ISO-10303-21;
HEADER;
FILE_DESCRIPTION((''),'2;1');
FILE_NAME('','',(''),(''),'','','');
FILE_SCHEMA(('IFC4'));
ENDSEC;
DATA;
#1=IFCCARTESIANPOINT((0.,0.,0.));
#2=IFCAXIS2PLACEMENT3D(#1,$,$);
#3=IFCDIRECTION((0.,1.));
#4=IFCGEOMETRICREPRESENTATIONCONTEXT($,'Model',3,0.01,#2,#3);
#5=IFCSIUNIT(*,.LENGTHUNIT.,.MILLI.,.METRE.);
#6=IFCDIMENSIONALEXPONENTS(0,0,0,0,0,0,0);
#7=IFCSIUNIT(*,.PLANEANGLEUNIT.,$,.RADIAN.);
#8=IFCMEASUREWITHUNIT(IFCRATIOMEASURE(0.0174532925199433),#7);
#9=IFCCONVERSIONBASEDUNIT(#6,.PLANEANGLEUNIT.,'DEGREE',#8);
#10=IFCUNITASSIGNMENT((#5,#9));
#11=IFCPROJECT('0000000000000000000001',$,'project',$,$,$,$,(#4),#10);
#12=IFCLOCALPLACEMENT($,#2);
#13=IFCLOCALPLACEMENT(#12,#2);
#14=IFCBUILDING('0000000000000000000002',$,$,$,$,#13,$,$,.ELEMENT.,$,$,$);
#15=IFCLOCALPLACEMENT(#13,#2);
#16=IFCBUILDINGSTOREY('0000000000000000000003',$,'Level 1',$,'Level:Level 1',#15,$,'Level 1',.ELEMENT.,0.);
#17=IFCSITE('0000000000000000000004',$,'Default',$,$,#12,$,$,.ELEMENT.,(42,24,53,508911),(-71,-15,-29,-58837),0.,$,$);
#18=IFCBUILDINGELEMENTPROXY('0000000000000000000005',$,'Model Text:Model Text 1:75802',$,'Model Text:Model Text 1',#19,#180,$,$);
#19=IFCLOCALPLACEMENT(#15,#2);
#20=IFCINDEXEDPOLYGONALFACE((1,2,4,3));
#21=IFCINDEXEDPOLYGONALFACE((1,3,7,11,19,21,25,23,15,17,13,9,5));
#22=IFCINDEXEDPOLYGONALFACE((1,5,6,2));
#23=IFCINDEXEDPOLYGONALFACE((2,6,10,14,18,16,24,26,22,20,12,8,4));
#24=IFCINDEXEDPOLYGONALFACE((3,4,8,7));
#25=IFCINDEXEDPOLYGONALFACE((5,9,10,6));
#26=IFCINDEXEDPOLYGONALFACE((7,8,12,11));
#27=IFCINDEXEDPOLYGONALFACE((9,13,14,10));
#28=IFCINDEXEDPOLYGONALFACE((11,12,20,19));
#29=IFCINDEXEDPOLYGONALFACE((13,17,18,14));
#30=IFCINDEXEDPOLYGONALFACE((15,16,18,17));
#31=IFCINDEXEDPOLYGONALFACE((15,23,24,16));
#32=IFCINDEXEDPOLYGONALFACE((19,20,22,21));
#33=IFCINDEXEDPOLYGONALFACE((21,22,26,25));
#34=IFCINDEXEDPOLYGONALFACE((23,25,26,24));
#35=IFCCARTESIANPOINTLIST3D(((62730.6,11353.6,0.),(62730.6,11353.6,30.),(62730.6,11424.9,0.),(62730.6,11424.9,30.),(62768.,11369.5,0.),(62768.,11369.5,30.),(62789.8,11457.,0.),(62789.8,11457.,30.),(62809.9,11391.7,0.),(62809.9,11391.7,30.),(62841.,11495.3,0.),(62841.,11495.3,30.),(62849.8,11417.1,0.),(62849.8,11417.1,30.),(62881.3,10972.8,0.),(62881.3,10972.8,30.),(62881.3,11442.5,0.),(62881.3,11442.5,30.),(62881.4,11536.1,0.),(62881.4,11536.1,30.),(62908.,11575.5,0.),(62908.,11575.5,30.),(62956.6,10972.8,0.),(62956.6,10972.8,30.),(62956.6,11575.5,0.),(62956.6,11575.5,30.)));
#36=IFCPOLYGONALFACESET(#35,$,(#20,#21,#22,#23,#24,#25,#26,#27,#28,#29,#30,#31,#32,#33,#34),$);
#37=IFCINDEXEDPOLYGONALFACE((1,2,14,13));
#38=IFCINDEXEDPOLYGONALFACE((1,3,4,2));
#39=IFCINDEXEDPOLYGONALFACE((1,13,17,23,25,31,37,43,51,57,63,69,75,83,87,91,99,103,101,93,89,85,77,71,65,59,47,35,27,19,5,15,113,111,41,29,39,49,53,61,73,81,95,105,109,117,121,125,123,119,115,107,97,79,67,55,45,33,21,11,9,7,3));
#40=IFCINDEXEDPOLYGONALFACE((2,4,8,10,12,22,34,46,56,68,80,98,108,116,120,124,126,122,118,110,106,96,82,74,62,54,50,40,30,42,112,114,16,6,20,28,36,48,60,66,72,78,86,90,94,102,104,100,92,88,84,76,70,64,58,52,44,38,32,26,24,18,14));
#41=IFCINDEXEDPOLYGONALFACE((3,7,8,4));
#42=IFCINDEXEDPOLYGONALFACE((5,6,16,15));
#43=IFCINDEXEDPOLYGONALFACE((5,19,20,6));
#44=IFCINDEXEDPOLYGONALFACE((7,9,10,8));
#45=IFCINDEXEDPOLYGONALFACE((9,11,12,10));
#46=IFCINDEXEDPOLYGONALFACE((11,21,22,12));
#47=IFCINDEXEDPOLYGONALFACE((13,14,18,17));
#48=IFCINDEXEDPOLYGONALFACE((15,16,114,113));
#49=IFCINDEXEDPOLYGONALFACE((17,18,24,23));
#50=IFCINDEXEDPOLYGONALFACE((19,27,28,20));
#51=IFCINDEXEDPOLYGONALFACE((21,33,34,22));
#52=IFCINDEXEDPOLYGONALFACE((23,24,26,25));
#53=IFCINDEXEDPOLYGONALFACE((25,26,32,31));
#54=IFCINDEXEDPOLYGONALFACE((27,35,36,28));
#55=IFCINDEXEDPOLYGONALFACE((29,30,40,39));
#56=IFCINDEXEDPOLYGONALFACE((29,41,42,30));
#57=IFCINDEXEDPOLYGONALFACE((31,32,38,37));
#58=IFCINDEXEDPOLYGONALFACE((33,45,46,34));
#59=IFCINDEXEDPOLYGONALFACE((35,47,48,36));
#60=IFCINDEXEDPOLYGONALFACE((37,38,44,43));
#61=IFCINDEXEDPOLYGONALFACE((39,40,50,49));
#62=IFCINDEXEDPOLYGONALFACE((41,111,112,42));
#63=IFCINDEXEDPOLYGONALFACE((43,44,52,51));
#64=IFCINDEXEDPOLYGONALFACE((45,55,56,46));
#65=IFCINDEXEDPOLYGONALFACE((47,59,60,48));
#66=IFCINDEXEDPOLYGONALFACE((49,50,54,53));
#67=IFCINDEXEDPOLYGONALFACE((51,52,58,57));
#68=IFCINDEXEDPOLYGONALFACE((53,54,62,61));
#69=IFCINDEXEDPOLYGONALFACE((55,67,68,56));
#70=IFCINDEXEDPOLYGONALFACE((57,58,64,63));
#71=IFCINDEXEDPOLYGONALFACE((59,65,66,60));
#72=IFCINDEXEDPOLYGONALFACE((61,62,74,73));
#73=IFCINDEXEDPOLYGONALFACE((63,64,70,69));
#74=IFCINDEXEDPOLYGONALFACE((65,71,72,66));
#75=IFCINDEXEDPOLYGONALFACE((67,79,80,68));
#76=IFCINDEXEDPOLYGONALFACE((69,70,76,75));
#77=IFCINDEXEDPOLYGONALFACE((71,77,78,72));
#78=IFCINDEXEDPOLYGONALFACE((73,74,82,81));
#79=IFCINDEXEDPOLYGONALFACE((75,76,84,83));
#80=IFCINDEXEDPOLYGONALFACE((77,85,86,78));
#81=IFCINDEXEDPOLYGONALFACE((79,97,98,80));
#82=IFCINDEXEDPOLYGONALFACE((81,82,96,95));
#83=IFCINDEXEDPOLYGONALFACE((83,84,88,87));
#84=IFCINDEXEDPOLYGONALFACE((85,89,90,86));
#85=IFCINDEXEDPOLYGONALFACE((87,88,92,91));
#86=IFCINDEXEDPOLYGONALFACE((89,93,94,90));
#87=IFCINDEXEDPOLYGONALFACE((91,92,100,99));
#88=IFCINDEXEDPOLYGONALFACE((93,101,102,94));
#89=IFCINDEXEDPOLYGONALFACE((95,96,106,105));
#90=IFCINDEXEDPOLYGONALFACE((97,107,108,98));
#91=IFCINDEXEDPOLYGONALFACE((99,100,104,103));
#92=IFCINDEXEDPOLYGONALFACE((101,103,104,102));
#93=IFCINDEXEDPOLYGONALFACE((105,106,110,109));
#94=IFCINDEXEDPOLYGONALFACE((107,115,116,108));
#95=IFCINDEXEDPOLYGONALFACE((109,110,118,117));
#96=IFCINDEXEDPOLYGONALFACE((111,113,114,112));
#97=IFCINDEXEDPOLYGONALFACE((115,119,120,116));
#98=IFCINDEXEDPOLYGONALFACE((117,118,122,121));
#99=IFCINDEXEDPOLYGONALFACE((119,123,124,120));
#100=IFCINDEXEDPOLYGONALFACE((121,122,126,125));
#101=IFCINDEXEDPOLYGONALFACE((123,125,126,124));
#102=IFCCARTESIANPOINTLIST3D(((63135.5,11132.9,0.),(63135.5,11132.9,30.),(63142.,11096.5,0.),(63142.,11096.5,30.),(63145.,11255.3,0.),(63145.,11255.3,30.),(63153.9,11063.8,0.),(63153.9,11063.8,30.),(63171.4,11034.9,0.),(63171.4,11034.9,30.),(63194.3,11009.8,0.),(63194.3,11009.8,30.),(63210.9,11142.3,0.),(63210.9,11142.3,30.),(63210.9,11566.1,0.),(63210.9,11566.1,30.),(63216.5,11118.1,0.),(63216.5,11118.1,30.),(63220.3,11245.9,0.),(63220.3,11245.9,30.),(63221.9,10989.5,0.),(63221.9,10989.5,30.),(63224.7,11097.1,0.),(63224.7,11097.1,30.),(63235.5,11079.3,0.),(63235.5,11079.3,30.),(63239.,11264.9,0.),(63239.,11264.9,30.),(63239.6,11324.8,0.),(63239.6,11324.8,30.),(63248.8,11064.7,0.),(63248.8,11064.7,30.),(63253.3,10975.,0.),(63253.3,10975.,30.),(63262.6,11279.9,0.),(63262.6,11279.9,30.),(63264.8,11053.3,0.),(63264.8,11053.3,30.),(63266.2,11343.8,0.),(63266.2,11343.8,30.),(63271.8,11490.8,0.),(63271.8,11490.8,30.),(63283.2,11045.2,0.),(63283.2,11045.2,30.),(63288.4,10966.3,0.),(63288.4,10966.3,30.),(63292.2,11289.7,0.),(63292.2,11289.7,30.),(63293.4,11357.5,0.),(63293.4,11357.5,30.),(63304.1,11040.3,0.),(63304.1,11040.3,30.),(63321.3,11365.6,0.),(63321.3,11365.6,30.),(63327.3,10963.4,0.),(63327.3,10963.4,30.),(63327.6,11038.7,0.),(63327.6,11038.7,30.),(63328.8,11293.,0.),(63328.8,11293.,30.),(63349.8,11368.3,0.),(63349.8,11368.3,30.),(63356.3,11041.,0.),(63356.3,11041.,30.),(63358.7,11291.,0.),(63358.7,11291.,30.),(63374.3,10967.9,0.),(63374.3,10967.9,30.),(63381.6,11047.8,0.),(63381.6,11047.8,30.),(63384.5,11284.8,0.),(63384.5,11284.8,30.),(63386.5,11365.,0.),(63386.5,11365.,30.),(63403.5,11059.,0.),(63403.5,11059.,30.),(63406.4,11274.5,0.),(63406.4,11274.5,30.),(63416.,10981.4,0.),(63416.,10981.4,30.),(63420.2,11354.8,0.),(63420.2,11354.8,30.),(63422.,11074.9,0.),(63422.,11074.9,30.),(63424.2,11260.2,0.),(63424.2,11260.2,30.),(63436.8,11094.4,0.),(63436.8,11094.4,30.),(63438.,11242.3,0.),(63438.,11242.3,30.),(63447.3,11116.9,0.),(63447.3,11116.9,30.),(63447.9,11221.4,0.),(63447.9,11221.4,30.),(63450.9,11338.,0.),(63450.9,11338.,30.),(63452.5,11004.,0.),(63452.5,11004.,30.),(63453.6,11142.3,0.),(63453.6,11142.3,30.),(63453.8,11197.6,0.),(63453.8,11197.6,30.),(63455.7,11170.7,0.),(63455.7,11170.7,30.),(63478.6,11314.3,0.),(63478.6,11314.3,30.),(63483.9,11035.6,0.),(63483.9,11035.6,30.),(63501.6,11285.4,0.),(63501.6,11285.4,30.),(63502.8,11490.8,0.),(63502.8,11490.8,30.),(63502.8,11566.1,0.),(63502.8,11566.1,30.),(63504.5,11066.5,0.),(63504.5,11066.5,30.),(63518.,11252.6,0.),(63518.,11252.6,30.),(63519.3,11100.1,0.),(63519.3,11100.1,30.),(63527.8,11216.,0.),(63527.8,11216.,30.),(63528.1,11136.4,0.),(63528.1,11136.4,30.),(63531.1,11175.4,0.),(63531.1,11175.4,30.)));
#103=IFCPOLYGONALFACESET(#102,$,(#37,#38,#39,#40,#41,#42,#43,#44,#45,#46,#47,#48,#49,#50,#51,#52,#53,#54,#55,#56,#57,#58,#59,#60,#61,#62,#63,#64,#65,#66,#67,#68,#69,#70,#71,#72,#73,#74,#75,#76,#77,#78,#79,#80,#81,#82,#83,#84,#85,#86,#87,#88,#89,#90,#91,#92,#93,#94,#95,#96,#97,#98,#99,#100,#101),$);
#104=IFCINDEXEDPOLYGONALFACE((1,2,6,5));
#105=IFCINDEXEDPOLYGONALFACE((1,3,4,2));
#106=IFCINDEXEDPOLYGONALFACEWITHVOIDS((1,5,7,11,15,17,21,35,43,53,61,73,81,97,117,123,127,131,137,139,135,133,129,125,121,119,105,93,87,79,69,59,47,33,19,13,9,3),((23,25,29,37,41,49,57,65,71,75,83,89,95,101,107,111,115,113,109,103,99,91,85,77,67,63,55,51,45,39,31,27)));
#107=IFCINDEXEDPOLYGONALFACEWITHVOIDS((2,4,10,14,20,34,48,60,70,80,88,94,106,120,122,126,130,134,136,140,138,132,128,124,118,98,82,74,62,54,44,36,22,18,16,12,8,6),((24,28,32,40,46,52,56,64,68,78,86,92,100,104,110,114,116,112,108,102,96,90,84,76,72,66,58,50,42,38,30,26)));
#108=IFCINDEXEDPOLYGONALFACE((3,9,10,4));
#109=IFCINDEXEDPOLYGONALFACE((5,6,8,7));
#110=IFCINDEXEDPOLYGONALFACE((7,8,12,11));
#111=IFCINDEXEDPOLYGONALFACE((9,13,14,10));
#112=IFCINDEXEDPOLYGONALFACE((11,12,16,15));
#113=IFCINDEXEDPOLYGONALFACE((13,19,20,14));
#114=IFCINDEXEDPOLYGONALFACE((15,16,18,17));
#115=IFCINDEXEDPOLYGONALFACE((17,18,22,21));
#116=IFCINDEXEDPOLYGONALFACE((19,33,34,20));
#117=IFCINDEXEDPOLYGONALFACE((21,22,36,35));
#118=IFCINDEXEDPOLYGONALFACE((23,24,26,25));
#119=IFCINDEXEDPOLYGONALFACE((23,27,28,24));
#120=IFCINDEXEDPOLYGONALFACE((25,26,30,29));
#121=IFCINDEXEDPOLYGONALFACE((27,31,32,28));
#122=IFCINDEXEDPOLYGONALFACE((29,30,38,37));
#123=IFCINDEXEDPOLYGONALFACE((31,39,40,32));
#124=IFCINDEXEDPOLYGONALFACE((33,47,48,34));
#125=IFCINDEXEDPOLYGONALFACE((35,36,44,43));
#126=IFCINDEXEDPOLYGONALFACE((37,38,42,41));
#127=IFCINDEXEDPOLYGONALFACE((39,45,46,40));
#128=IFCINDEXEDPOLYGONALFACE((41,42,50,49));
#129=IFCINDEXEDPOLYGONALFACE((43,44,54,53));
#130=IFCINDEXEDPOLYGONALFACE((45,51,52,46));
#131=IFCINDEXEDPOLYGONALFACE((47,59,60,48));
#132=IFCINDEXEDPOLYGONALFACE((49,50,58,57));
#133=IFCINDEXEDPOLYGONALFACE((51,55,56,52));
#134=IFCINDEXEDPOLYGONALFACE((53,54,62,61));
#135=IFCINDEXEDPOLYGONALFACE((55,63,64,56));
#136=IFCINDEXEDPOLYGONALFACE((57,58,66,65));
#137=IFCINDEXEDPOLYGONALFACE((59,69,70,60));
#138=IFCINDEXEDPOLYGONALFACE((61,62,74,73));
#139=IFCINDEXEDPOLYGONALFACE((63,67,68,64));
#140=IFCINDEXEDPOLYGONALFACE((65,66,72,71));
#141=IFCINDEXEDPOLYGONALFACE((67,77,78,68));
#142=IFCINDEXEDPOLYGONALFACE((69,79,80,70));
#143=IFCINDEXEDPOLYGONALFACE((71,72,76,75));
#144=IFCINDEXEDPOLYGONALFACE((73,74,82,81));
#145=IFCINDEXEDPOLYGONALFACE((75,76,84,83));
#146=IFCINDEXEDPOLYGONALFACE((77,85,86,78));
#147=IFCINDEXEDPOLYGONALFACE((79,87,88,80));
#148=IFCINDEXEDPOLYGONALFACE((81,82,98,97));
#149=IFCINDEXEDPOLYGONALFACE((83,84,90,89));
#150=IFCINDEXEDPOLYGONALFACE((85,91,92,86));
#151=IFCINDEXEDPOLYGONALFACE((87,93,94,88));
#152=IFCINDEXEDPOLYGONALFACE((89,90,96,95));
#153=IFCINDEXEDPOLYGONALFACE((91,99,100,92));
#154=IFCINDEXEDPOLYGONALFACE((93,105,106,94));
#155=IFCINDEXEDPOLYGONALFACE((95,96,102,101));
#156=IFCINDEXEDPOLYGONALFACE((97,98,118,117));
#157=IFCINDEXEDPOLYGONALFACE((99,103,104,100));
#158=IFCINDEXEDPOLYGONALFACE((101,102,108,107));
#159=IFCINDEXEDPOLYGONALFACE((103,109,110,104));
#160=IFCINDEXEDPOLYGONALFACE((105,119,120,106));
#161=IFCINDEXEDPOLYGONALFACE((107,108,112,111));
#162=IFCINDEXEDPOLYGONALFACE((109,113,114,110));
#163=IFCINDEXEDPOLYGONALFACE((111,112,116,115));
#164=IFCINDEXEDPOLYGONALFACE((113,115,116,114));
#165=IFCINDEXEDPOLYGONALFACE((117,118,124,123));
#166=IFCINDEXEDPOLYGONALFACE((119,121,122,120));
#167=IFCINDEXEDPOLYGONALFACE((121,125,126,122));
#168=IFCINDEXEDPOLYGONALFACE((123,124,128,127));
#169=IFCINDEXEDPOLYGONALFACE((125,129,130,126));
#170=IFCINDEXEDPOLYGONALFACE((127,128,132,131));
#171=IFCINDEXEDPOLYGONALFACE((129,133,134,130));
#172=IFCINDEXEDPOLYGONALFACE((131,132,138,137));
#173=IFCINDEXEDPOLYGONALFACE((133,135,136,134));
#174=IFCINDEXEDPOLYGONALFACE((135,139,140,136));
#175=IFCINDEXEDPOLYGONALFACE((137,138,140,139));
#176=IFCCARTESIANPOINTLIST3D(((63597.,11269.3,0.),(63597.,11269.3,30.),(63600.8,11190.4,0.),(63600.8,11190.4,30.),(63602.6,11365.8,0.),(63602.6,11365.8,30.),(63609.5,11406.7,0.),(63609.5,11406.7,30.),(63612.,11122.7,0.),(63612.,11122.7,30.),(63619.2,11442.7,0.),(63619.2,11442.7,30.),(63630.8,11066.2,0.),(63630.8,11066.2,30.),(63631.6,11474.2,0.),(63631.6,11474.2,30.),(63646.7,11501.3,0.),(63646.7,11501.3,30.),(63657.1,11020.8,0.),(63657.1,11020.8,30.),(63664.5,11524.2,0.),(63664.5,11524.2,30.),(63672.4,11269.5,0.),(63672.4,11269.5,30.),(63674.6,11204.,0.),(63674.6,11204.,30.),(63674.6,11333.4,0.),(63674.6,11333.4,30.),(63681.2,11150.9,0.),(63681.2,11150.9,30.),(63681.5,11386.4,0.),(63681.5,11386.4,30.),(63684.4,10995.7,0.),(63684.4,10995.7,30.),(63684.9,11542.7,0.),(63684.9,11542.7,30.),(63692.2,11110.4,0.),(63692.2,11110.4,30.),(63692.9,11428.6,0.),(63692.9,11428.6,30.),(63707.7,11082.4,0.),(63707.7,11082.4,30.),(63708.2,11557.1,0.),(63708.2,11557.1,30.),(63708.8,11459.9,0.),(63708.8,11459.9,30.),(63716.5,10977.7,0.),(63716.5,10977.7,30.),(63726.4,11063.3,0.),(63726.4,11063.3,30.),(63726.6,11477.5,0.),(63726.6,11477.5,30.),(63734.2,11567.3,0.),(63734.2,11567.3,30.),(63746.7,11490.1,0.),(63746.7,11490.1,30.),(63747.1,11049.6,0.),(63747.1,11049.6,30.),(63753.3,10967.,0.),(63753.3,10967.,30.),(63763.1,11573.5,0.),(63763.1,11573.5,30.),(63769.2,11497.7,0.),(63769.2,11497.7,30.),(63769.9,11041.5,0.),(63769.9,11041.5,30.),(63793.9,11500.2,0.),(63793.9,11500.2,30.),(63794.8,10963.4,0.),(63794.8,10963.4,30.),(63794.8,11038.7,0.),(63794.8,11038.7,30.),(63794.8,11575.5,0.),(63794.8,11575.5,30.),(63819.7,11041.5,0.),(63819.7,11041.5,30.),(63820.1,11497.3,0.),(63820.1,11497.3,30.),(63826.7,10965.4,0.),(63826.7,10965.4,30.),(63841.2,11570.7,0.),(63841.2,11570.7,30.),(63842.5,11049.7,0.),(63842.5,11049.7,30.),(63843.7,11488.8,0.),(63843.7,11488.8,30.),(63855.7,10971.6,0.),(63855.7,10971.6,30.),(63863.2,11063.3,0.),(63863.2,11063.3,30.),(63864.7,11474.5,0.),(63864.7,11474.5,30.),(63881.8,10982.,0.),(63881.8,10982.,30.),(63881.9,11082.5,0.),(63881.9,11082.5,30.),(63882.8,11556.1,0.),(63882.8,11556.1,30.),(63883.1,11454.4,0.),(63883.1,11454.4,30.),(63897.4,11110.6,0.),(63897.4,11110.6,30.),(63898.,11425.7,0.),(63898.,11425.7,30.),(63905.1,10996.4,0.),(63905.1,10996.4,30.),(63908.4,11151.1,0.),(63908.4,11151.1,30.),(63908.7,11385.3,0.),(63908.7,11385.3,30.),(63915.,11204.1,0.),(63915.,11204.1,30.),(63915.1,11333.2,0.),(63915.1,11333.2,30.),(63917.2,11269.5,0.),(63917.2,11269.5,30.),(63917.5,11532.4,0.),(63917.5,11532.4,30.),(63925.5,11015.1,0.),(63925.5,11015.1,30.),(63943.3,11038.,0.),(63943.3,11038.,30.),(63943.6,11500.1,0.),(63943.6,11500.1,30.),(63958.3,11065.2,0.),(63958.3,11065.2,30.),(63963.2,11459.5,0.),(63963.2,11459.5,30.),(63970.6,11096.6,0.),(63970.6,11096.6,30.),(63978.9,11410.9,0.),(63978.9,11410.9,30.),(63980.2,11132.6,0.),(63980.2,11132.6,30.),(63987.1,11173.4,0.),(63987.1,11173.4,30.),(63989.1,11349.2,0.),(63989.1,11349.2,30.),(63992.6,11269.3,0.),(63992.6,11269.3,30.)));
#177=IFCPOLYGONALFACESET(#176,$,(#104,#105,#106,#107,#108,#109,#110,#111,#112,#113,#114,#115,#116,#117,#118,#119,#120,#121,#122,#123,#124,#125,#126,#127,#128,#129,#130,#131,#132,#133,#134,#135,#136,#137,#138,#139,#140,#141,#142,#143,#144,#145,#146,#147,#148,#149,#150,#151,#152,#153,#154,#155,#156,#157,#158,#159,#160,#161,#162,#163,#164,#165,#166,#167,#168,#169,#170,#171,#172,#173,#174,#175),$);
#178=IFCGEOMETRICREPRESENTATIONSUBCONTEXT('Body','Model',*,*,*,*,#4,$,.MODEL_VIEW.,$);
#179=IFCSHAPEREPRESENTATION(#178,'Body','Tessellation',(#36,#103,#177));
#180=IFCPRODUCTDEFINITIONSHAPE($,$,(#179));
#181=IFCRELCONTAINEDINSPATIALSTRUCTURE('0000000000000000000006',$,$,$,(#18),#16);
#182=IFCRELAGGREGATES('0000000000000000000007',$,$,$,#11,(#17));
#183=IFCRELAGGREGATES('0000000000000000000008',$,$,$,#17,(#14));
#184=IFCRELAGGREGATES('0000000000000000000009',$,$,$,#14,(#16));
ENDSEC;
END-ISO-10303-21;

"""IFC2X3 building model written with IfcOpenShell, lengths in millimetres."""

from ifc_helpers import new_model, entity, si_unit, converted_unit, direction, frame, origin, place, context, subcontext, project, spatial, polyline, outline, extrude, element, save


model = new_model("IFC2X3")

# Units and contexts
model_context = context("Model", 3, precision=0.01, world=origin(), true_north=direction((0.0, 1.0)))
body_context = subcontext(model_context, "Body", "Model", "MODEL_VIEW")
ifc_project = project(units=[si_unit("LENGTHUNIT", "METRE", prefix="MILLI"), converted_unit("PLANEANGLEUNIT", "DEGREE", entity("IfcRatioMeasure", 0.0174532925199433), si_unit("PLANEANGLEUNIT", "RADIAN"), dimensions=[0, 0, 0, 0, 0, 0, 0])], contexts=[model_context])

# Site, building, storey
site_placement = place(None, origin())
site = spatial("IfcSite", under=ifc_project, at=site_placement, Name="Default", CompositionType="ELEMENT", RefLatitude=(42, 24, 53, 508911), RefLongitude=(-71, -15, -29, -58837), RefElevation=0.0)
building_placement = place(site_placement, origin())
building = spatial("IfcBuilding", under=site, at=building_placement, CompositionType="ELEMENT")
storey_placement = place(building_placement, origin())
storey = spatial("IfcBuildingStorey", under=building, at=storey_placement, Name="Level 1", ObjectType="Level:Level 1", LongName="Level 1", CompositionType="ELEMENT", Elevation=0.0)

# Building element proxy
proxy_1_placement = place(storey_placement, origin())
element("IfcBuildingElementProxy", 1, at=proxy_1_placement, inside=storey, Name="Model Text:Model Text 1:75802", ObjectType="Model Text:Model Text 1", context=body_context, shape_type="SweptSolid", body=[
    extrude(outline(polyline([(-410.6, -111.6), (192.1, -111.6), (192.1, -63.1), (152.7, -36.4), (111.9, 4.0), (73.6, 55.2), (41.4, 114.4), (-29.8, 114.4), (-13.9, 77.0), (8.3, 35.1), (33.7, -4.8), (59.1, -36.3), (-410.6, -36.3), (-410.6, -111.6)])), frame((62845.0, 11383.4, 0.0), z_axis=(0.0, 0.0, 1.0), x_axis=(0.0, 1.0, 0.0)), (0.0, 0.0, 1.0), 30.0),
    extrude(outline(polyline([(12.1, -219.3), (49.1, -219.3), (83.4, -213.2), (114.8, -201.1), (143.5, -182.8), (168.3, -159.2), (188.1, -130.8), (202.8, -97.8), (212.4, -60.0), (216.1, -12.9), (210.0, 30.5), (194.1, 70.4), (168.4, 106.8), (141.6, 132.5), (111.1, 152.9), (76.9, 167.9), (39.0, 177.6), (-1.5, 181.4), (-39.3, 178.1), (-74.4, 167.6), (-106.9, 150.1), (-135.0, 126.9), (-157.0, 99.6), (-172.8, 68.1), (-182.5, 32.6), (-184.8, 4.0), (-181.6, -24.8), (-172.9, -54.0), (-158.8, -83.5), (-316.6, -22.9), (-276.5, 204.6), (-350.7, 217.7), (-401.4, -69.8), (-106.8, -188.8), (-84.5, -116.2), (-99.9, -94.5), (-110.6, -68.6), (-115.1, -37.8), (-112.0, -1.2), (-104.8, 27.9), (-94.2, 52.3), (-80.3, 72.0), (-63.1, 87.0), (-43.0, 97.5), (-20.8, 103.6), (3.8, 105.3), (30.5, 102.6), (58.1, 95.6), (82.1, 84.9), (102.4, 70.6), (119.1, 52.7), (131.4, 31.7), (138.7, 8.2), (141.0, -17.9), (138.2, -46.6), (132.6, -69.4), (124.1, -89.2), (112.9, -105.9), (99.0, -119.6), (82.3, -130.2), (62.9, -137.7), (40.8, -142.2), (15.9, -143.5), (12.1, -219.3)])), frame((63349.4, 11183.0, 0.0), z_axis=(0.0, 0.0, 1.0), x_axis=(0.173842, -0.984774, 0.0)), (0.0, 0.0, 1.0), 30.0),
    extrude(outline(polyline([(-10.6, -198.7), (68.3, -198.7), (136.5, -190.7), (193.9, -174.7), (240.5, -150.6), (266.9, -124.4), (286.3, -93.2), (298.8, -57.0), (304.3, -15.7), (303.8, 16.2), (299.0, 45.5), (289.9, 72.1), (276.6, 96.0), (258.9, 117.3), (236.9, 136.2), (210.4, 152.5), (179.6, 166.3), (144.1, 177.6), (103.7, 186.3), (8.2, 196.4), (-71.8, 196.7), (-134.0, 189.4), (-183.3, 176.1), (-224.7, 158.4), (-258.2, 133.9), (-283.5, 100.3), (-300.1, 59.5), (-307.1, 13.4), (-306.6, -18.4), (-301.8, -47.5), (-292.8, -74.0), (-279.6, -97.9), (-262.0, -119.2), (-240.0, -138.1), (-213.6, -154.5), (-182.8, -168.4), (-147.3, -179.8), (-106.7, -188.6), (-10.6, -198.7)]), holes=[polyline([(-7.2, -123.5), (-71.0, -118.2), (-123.6, -108.8), (-165.2, -95.4), (-195.7, -78.0), (-212.4, -59.4), (-224.1, -38.7), (-230.6, -15.9), (-231.9, 8.9), (-227.8, 35.0), (-218.1, 58.1), (-202.8, 78.4), (-182.0, 95.8), (-152.6, 109.4), (-111.7, 118.1), (-59.4, 122.0), (4.4, 121.1), (69.6, 115.8), (122.2, 106.7), (162.2, 93.7), (189.5, 77.0), (207.7, 57.4), (220.4, 36.0), (227.5, 12.8), (229.1, -12.1), (225.2, -36.8), (215.9, -59.2), (201.3, -79.3), (181.4, -97.1), (152.6, -111.2), (111.6, -120.3), (58.3, -124.4), (-7.2, -123.5)])]), frame((63796.0, 11268.1, 0.0), z_axis=(0.0, 0.0, 1.0), x_axis=(0.047515, -0.998871, 0.0)), (0.0, 0.0, 1.0), 30.0),
])

save(model, "model.ifc")
